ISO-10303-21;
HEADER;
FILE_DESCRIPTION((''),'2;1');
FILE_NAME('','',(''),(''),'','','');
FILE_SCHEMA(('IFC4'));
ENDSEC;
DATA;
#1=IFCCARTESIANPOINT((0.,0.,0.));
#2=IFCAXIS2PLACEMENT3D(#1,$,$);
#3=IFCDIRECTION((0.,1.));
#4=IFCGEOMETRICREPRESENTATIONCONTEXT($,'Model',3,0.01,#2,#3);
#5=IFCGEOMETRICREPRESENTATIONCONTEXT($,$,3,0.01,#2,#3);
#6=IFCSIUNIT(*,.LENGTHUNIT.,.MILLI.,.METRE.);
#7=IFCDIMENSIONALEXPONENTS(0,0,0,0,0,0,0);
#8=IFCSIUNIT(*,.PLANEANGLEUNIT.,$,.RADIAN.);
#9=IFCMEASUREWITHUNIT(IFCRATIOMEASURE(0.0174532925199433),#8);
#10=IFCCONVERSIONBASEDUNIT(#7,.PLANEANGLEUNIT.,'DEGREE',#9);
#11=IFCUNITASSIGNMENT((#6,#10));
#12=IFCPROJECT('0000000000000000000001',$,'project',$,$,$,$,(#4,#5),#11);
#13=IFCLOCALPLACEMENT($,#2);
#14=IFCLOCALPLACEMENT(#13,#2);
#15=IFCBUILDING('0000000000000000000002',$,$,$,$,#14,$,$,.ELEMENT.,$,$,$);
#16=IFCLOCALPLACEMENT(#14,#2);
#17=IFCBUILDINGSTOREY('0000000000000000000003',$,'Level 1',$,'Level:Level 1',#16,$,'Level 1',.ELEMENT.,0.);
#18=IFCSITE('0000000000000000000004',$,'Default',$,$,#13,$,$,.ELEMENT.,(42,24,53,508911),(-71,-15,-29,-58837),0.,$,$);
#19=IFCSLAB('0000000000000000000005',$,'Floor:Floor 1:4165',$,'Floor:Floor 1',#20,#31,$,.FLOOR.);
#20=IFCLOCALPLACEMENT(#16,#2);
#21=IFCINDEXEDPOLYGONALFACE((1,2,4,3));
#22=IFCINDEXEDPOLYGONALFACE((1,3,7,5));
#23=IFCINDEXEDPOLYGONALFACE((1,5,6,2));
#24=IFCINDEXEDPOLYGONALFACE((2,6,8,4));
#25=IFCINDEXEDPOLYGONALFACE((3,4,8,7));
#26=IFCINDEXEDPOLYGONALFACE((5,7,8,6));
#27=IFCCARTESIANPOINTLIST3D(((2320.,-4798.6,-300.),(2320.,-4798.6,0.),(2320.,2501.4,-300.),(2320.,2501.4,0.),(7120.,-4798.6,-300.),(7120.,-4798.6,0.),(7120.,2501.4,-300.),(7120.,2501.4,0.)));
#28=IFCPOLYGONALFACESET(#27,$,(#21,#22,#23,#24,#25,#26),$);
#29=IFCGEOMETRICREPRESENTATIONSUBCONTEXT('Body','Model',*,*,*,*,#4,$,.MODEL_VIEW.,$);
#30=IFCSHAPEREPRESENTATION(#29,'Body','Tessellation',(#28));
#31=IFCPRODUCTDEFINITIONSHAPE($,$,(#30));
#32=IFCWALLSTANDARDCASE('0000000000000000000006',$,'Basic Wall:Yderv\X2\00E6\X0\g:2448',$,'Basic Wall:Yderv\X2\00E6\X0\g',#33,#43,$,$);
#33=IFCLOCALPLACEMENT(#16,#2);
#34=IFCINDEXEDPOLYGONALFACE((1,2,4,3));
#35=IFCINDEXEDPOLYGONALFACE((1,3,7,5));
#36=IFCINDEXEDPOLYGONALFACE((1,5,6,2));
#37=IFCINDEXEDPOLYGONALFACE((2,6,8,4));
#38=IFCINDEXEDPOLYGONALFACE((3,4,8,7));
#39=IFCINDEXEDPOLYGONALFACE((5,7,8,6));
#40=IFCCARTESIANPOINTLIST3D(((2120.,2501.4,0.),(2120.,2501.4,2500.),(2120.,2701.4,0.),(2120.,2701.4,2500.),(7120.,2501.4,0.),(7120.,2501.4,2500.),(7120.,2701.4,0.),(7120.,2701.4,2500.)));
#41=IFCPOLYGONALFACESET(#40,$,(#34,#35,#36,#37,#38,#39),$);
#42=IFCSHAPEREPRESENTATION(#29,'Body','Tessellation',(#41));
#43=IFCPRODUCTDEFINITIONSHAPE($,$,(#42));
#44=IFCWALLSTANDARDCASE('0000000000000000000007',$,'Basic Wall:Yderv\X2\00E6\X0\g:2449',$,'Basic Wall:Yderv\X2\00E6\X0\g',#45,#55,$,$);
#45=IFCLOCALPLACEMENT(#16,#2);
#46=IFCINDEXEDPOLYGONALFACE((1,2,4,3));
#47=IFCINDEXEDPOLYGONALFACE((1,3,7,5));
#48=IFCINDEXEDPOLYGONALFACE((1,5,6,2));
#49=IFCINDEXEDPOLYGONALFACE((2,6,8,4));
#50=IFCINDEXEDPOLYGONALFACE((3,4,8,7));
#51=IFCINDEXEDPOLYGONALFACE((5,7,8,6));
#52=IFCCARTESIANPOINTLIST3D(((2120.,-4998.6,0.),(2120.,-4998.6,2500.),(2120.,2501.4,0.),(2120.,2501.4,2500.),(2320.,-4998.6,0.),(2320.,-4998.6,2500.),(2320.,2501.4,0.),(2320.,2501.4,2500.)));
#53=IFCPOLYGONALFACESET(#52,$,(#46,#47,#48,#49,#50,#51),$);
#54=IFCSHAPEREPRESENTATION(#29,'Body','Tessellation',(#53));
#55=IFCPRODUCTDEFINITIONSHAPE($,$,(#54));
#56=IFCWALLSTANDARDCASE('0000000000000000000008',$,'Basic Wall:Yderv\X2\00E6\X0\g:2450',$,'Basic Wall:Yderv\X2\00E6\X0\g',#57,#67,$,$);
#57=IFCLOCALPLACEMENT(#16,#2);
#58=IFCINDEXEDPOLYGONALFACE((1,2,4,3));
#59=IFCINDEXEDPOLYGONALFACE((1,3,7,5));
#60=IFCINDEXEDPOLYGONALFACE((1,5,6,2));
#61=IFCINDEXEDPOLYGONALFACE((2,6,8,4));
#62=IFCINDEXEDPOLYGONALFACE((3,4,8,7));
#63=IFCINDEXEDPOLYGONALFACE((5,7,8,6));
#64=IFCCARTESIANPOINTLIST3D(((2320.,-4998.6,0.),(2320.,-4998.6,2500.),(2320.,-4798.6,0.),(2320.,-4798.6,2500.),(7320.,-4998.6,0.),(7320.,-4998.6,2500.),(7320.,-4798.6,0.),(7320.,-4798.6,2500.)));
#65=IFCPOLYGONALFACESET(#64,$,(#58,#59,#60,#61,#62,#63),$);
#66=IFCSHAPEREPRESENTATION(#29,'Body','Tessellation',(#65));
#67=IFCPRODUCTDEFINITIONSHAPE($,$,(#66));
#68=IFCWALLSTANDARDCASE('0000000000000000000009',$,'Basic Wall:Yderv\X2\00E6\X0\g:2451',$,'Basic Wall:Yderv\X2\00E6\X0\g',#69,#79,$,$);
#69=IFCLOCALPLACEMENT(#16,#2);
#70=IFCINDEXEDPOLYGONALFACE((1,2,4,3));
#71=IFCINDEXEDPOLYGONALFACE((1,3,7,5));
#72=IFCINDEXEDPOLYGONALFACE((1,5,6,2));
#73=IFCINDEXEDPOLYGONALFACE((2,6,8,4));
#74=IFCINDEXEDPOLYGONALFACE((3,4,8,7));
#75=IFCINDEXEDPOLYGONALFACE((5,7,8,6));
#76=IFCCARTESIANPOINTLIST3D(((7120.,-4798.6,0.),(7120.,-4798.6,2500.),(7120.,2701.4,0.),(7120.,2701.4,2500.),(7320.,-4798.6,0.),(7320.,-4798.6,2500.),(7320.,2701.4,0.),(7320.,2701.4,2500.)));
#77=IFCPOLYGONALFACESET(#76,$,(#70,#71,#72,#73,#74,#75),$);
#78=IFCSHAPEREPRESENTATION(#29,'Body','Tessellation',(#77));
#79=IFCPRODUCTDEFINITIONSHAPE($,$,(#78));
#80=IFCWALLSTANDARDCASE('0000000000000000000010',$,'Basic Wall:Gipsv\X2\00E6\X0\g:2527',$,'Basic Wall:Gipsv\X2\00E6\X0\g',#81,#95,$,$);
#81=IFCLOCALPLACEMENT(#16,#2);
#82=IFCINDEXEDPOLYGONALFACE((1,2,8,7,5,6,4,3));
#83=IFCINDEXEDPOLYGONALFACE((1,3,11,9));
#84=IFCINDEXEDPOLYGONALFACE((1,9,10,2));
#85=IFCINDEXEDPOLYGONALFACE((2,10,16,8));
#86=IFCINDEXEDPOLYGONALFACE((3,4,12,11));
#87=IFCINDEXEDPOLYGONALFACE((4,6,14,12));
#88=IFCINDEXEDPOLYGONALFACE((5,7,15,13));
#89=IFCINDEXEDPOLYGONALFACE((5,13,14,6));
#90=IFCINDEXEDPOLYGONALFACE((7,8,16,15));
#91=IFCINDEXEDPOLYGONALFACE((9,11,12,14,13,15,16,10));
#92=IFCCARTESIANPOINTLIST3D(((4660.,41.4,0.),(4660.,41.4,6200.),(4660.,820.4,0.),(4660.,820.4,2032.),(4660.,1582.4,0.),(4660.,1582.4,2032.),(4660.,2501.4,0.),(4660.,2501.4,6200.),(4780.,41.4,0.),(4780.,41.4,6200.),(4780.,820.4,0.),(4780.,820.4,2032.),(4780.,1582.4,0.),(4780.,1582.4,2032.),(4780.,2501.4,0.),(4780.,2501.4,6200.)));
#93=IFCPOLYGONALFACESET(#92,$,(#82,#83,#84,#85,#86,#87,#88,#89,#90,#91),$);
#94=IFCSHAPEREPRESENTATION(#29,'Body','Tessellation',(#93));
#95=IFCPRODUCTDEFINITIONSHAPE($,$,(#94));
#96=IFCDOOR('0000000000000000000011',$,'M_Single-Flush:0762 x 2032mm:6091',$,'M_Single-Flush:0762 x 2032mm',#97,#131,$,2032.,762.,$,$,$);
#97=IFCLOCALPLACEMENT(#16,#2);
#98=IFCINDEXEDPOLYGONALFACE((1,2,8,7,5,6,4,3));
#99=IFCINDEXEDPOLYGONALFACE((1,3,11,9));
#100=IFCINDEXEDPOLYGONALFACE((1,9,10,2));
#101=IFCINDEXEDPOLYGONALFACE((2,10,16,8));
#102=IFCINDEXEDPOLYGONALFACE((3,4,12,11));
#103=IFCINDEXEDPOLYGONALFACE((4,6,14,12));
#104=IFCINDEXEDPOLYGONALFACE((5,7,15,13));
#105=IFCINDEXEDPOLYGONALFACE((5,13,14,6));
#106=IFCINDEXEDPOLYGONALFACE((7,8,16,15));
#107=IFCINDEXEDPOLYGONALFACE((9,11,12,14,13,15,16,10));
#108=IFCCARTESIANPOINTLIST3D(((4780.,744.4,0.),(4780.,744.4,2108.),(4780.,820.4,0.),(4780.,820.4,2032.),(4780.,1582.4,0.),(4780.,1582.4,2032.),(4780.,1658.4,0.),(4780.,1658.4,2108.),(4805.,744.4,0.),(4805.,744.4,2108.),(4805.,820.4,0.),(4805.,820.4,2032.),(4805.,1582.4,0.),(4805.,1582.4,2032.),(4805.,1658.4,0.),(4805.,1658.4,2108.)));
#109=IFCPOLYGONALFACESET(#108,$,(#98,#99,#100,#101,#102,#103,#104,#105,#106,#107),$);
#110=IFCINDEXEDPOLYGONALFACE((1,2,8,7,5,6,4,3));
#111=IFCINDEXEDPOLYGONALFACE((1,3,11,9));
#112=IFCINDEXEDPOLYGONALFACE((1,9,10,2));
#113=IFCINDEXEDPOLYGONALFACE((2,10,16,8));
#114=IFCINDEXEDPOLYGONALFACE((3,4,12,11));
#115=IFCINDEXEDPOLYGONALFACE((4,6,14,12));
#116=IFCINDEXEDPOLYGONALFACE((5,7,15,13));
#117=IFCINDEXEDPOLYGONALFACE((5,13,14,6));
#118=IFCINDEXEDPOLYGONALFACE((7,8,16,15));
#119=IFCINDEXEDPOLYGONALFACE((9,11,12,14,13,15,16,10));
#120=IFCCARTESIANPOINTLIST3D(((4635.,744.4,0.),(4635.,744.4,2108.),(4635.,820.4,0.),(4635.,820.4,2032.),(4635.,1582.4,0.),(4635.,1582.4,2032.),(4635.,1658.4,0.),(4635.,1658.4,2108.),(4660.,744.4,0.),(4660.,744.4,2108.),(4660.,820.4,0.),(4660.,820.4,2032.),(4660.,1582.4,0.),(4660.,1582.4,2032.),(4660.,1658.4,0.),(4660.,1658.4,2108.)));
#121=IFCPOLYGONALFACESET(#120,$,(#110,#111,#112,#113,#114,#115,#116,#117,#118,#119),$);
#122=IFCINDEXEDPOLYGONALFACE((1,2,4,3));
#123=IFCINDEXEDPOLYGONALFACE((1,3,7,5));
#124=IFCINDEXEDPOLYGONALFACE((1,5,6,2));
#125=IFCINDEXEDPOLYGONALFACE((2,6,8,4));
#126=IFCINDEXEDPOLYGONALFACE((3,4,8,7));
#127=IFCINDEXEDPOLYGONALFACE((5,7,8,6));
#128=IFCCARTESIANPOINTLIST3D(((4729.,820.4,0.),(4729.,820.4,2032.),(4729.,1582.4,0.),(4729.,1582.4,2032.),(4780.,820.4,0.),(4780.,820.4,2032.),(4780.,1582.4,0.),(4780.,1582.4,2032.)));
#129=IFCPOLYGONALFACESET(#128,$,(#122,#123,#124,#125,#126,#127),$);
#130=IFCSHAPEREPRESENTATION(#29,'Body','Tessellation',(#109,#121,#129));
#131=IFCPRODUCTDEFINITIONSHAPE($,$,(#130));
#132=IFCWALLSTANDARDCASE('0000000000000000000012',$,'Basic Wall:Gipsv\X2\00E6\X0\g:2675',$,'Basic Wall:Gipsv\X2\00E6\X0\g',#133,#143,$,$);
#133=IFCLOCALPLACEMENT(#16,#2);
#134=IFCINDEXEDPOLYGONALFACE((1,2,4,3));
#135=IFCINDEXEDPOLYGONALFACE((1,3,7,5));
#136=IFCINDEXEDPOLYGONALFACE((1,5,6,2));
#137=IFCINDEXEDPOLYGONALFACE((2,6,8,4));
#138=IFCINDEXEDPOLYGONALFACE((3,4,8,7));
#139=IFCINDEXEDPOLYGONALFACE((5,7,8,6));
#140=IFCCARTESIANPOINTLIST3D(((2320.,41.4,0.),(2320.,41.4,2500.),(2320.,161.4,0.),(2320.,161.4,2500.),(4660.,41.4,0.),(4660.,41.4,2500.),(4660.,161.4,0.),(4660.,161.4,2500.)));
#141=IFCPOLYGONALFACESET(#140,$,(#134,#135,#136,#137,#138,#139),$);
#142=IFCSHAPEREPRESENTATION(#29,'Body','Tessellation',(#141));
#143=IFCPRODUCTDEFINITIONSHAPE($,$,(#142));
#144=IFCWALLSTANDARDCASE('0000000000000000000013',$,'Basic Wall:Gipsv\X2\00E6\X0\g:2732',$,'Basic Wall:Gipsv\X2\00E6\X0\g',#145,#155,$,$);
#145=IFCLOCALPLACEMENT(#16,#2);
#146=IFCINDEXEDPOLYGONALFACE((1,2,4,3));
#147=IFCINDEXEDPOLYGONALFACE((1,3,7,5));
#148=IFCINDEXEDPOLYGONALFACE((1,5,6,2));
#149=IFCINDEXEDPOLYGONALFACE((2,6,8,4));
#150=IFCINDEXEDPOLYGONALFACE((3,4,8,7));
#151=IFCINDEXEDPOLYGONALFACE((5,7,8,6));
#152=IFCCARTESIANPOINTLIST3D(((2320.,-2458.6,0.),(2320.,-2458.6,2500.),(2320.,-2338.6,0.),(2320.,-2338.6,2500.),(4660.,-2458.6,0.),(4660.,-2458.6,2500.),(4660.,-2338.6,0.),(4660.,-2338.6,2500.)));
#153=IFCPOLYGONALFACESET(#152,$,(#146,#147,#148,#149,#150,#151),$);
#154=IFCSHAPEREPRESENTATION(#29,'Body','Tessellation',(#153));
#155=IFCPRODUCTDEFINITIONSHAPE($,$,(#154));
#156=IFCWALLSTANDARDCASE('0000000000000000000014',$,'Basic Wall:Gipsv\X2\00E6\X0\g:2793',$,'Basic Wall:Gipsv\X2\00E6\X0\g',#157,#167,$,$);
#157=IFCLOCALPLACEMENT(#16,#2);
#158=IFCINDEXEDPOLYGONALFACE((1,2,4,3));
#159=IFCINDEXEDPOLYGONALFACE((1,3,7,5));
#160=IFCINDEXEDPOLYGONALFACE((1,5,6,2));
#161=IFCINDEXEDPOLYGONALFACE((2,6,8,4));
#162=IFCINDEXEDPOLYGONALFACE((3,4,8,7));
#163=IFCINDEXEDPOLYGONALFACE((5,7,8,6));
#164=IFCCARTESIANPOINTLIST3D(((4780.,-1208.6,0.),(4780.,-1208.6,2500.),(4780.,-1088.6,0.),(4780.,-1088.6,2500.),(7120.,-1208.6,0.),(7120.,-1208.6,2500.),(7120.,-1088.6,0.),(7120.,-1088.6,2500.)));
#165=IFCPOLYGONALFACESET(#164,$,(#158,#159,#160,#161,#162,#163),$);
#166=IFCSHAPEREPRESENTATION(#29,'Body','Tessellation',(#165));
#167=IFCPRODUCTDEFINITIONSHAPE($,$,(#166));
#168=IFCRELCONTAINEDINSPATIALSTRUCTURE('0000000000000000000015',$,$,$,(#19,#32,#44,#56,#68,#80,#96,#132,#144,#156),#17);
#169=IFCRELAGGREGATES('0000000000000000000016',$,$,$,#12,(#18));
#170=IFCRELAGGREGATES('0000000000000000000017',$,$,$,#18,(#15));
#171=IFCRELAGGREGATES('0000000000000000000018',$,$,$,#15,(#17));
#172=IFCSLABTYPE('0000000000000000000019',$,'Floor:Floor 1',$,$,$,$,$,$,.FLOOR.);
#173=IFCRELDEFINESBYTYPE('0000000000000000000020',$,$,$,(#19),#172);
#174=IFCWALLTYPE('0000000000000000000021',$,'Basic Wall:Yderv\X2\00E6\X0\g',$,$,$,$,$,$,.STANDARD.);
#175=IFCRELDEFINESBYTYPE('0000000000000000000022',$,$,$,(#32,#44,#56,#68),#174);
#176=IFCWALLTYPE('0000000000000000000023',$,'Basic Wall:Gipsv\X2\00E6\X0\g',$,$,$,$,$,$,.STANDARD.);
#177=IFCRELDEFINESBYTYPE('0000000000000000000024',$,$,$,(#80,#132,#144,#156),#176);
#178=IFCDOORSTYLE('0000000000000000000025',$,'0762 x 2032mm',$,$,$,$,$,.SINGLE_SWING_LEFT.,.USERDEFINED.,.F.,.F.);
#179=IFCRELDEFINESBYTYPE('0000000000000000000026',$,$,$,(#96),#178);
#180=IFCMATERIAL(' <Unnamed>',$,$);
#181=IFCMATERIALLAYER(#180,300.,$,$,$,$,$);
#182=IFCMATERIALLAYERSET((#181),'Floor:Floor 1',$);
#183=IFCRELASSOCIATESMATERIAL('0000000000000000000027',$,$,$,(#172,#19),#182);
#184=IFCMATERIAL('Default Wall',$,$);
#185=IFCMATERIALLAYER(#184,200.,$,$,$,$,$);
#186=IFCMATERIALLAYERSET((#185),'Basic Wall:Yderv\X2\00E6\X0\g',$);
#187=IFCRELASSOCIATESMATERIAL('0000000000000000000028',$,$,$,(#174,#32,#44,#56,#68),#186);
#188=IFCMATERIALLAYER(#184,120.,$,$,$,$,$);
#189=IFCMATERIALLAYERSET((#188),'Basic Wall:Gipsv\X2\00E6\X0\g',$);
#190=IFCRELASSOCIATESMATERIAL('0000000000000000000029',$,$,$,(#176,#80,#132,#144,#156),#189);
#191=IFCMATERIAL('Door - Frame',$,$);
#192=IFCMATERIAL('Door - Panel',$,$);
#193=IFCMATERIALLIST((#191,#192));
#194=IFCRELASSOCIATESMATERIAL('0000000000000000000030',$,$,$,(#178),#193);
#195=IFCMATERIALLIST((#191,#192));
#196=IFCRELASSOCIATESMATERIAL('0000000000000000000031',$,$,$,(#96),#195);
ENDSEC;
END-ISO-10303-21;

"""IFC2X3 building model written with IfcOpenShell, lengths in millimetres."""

from ifc_helpers import new_model, entity, si_unit, converted_unit, direction, frame, frame_2d, origin, origin_2d_with_axis, place, context, subcontext, project, spatial, polyline, rectangle, outline, extrude, source, transform, mapped, material, material_list, layer, layer_set, layer_usage, type_object, type_shapes, element, fill, save


model = new_model("IFC2X3")

# Units and contexts
model_context = context("Model", 3, precision=0.01, world=origin(), true_north=direction((0.0, 1.0)))
context_of_model = context(None, 3, precision=0.01, world=origin(), true_north=direction((0.0, 1.0)))
body_context = subcontext(model_context, "Body", "Model", "MODEL_VIEW")
ifc_project = project(units=[si_unit("LENGTHUNIT", "METRE", prefix="MILLI"), converted_unit("PLANEANGLEUNIT", "DEGREE", entity("IfcRatioMeasure", 0.0174532925199433), si_unit("PLANEANGLEUNIT", "RADIAN"), dimensions=[0, 0, 0, 0, 0, 0, 0])], contexts=[model_context, context_of_model])

# Site, building, storey
site_placement = place(None, origin())
site = spatial("IfcSite", under=ifc_project, at=site_placement, Name="Default", CompositionType="ELEMENT", RefLatitude=(42, 24, 53, 508911), RefLongitude=(-71, -15, -29, -58837), RefElevation=0.0)
building_placement = place(site_placement, origin())
building = spatial("IfcBuilding", under=site, at=building_placement, CompositionType="ELEMENT")
storey_placement = place(building_placement, origin())
storey = spatial("IfcBuildingStorey", under=building, at=storey_placement, Name="Level 1", ObjectType="Level:Level 1", LongName="Level 1", CompositionType="ELEMENT", Elevation=0.0)

# Slab
ifc_material_1 = material(Name=" <Unnamed>")
ifc_layer_1 = layer(ifc_material_1, 300.0)
ifc_layer_set_1 = layer_set([ifc_layer_1], Name="Floor:Floor 1")
ifc_layer_usage_1 = layer_usage(ifc_layer_set_1, "AXIS3", "POSITIVE", 0.0)
slab_type = type_object("IfcSlabType", Name="Floor:Floor 1", PredefinedType="FLOOR", material=ifc_layer_set_1)
slab_placement = place(storey_placement, origin())
element("IfcSlab", 1, at=slab_placement, inside=storey, type_object=slab_type, material=ifc_layer_usage_1, Name="Floor:Floor 1:4165", ObjectType="Floor:Floor 1", PredefinedType="FLOOR", context=body_context, shape_type="SweptSolid", body=[
    extrude(rectangle(XDim=7300.0, YDim=4800.0, at=origin_2d_with_axis()), frame((4720.0, -1148.6, 0.0), z_axis=(0.0, 0.0, -1.0), x_axis=(0.0, 1.0, 0.0)), (0.0, 0.0, 1.0), 300.0),
])

# Walls
ifc_material_2 = material(Name="Default Wall")
ifc_layer_2 = layer(ifc_material_2, 200.0)
ifc_layer_set_2 = layer_set([ifc_layer_2], Name="Basic Wall:Ydervæg")
ifc_layer_usage_2 = layer_usage(ifc_layer_set_2, "AXIS2", "NEGATIVE", 100.0)
wall_type_1 = type_object("IfcWallType", Name="Basic Wall:Ydervæg", PredefinedType="STANDARD", material=ifc_layer_set_2)
wall_1_placement = place(storey_placement, frame((2120.0, 2601.4, 0.0)))
element("IfcWallStandardCase", 2, at=wall_1_placement, inside=storey, type_object=wall_type_1, material=ifc_layer_usage_2, Name="Basic Wall:Ydervæg:2448", ObjectType="Basic Wall:Ydervæg", context=body_context, shape_type="SweptSolid", body=[
    extrude(rectangle(XDim=5000.0, YDim=200.0, at=frame_2d((2500.0, 0.0), x_axis=(-1.0, 0.0))), origin(), (0.0, 0.0, 1.0), 2500.0),
])
ifc_layer_usage_3 = layer_usage(ifc_layer_set_2, "AXIS2", "NEGATIVE", 100.0)
wall_2_placement = place(storey_placement, frame((2220.0, -4998.6, 0.0), z_axis=(0.0, 0.0, 1.0), x_axis=(0.0, 1.0, 0.0)))
element("IfcWallStandardCase", 3, at=wall_2_placement, inside=storey, type_object=wall_type_1, material=ifc_layer_usage_3, Name="Basic Wall:Ydervæg:2449", ObjectType="Basic Wall:Ydervæg", context=body_context, shape_type="SweptSolid", body=[
    extrude(rectangle(XDim=7500.0, YDim=200.0, at=frame_2d((3750.0, 0.0), x_axis=(-1.0, 0.0))), origin(), (0.0, 0.0, 1.0), 2500.0),
])
ifc_layer_usage_4 = layer_usage(ifc_layer_set_2, "AXIS2", "NEGATIVE", 100.0)
wall_3_placement = place(storey_placement, frame((7320.0, -4898.6, 0.0), z_axis=(0.0, 0.0, 1.0), x_axis=(-1.0, 0.0, 0.0)))
element("IfcWallStandardCase", 4, at=wall_3_placement, inside=storey, type_object=wall_type_1, material=ifc_layer_usage_4, Name="Basic Wall:Ydervæg:2450", ObjectType="Basic Wall:Ydervæg", context=body_context, shape_type="SweptSolid", body=[
    extrude(rectangle(XDim=5000.0, YDim=200.0, at=frame_2d((2500.0, 0.0), x_axis=(-1.0, 0.0))), origin(), (0.0, 0.0, 1.0), 2500.0),
])
ifc_layer_usage_5 = layer_usage(ifc_layer_set_2, "AXIS2", "NEGATIVE", 100.0)
wall_4_placement = place(storey_placement, frame((7220.0, 2701.4, 0.0), z_axis=(0.0, 0.0, 1.0), x_axis=(0.0, -1.0, 0.0)))
element("IfcWallStandardCase", 5, at=wall_4_placement, inside=storey, type_object=wall_type_1, material=ifc_layer_usage_5, Name="Basic Wall:Ydervæg:2451", ObjectType="Basic Wall:Ydervæg", context=body_context, shape_type="SweptSolid", body=[
    extrude(rectangle(XDim=7500.0, YDim=200.0, at=frame_2d((3750.0, 0.0), x_axis=(-1.0, 0.0))), origin(), (0.0, 0.0, 1.0), 2500.0),
])

# Wall, opening, door
ifc_layer_3 = layer(ifc_material_2, 120.0)
ifc_layer_set_3 = layer_set([ifc_layer_3], Name="Basic Wall:Gipsvæg")
ifc_layer_usage_6 = layer_usage(ifc_layer_set_3, "AXIS2", "NEGATIVE", 60.0)
wall_type_2 = type_object("IfcWallType", Name="Basic Wall:Gipsvæg", PredefinedType="STANDARD", material=ifc_layer_set_3)
wall_5_placement = place(storey_placement, frame((4720.0, 2501.4, 0.0), z_axis=(0.0, 0.0, 1.0), x_axis=(0.0, -1.0, 0.0)))
wall_5 = element("IfcWallStandardCase", 6, at=wall_5_placement, inside=storey, type_object=wall_type_2, material=ifc_layer_usage_6, Name="Basic Wall:Gipsvæg:2527", ObjectType="Basic Wall:Gipsvæg", context=body_context, shape_type="SweptSolid", body=[
    extrude(rectangle(XDim=2460.0, YDim=120.0, at=frame_2d((1230.0, 0.0), x_axis=(-1.0, 0.0))), origin(), (0.0, 0.0, 1.0), 6200.0),
])
opening_placement = place(wall_5_placement, frame((919.0, -60.0, 0.0)))
opening = element("IfcOpeningElement", 7, at=opening_placement, cuts=wall_5, ObjectType="Opening", context=body_context, shape_type="SweptSolid", body=[
    extrude(rectangle(XDim=762.0, YDim=2032.0, at=frame_2d((1016.0, 381.0), x_axis=(0.0, -1.0))), frame((0.0, 0.0, 0.0), z_axis=(0.0, 1.0, 0.0), x_axis=(0.0, 0.0, 1.0)), (0.0, 0.0, 1.0), 120.0),
])
ifc_material_3 = material(Name="Door - Frame")
ifc_material_4 = material(Name="Door - Panel")
ifc_material_list_1 = material_list([ifc_material_3, ifc_material_4])
ifc_material_list_2 = material_list([ifc_material_3, ifc_material_4])
door_style = type_object("IfcDoorStyle", Name="0762 x 2032mm", ConstructionType="USERDEFINED", OperationType="SINGLE_SWING_LEFT", ParameterTakesPrecedence=False, Sizeable=False, material=ifc_material_list_2)
shared_shape = source(origin(), body_context, "Body", "SweptSolid", [
    extrude(outline(polyline([(-457.0, -1073.0), (457.0, -1073.0), (457.0, 1035.0), (381.0, 1035.0), (381.0, -997.0), (-381.0, -997.0), (-381.0, 1035.0), (-457.0, 1035.0), (-457.0, -1073.0)])), frame((381.0, 145.0, 1035.0), z_axis=(0.0, -1.0, 0.0), x_axis=(-1.0, 0.0, 0.0)), (0.0, 0.0, 1.0), 25.0),
    extrude(outline(polyline([(-1073.0, -457.0), (1035.0, -457.0), (1035.0, -381.0), (-997.0, -381.0), (-997.0, 381.0), (1035.0, 381.0), (1035.0, 457.0), (-1073.0, 457.0), (-1073.0, -457.0)])), frame((381.0, 0.0, 1035.0), z_axis=(0.0, -1.0, 0.0), x_axis=(0.0, 0.0, -1.0)), (0.0, 0.0, 1.0), 25.0),
    extrude(rectangle(XDim=762.0, YDim=51.0, at=frame_2d((0.0, 0.0), x_axis=(1.0, 0.0))), frame((381.0, 94.5, 0.0)), (0.0, 0.0, 1.0), 2032.0),
])
type_shapes(door_style, [shared_shape])
door_placement = place(opening_placement, origin())
door = element("IfcDoor", 8, at=door_placement, inside=storey, type_object=door_style, material=ifc_material_list_1, Name="M_Single-Flush:0762 x 2032mm:6091", ObjectType="M_Single-Flush:0762 x 2032mm", OverallHeight=2032.0, OverallWidth=762.0, context=body_context, shape_type="MappedRepresentation", body=[
    mapped(shared_shape, transform((0.0, 0.0, 0.0), scale=1.0)),
])
fill(opening, door)

# Walls
ifc_layer_usage_7 = layer_usage(ifc_layer_set_3, "AXIS2", "NEGATIVE", 60.0)
wall_6_placement = place(storey_placement, frame((2320.0, 101.4, 0.0)))
element("IfcWallStandardCase", 9, at=wall_6_placement, inside=storey, type_object=wall_type_2, material=ifc_layer_usage_7, Name="Basic Wall:Gipsvæg:2675", ObjectType="Basic Wall:Gipsvæg", context=body_context, shape_type="SweptSolid", body=[
    extrude(rectangle(XDim=2340.0, YDim=120.0, at=frame_2d((1170.0, 0.0), x_axis=(-1.0, 0.0))), origin(), (0.0, 0.0, 1.0), 2500.0),
])
ifc_layer_usage_8 = layer_usage(ifc_layer_set_3, "AXIS2", "POSITIVE", -60.0)
wall_7_placement = place(storey_placement, frame((2320.0, -2398.6, 0.0)))
element("IfcWallStandardCase", 10, at=wall_7_placement, inside=storey, type_object=wall_type_2, material=ifc_layer_usage_8, Name="Basic Wall:Gipsvæg:2732", ObjectType="Basic Wall:Gipsvæg", context=body_context, shape_type="SweptSolid", body=[
    extrude(rectangle(XDim=2340.0, YDim=120.0, at=frame_2d((1170.0, 0.0), x_axis=(-1.0, 0.0))), origin(), (0.0, 0.0, 1.0), 2500.0),
])
ifc_layer_usage_9 = layer_usage(ifc_layer_set_3, "AXIS2", "NEGATIVE", 60.0)
wall_8_placement = place(storey_placement, frame((4780.0, -1148.6, 0.0)))
element("IfcWallStandardCase", 11, at=wall_8_placement, inside=storey, type_object=wall_type_2, material=ifc_layer_usage_9, Name="Basic Wall:Gipsvæg:2793", ObjectType="Basic Wall:Gipsvæg", context=body_context, shape_type="SweptSolid", body=[
    extrude(rectangle(XDim=2340.0, YDim=120.0, at=frame_2d((1170.0, 0.0), x_axis=(-1.0, 0.0))), origin(), (0.0, 0.0, 1.0), 2500.0),
])

save(model, "model.ifc")
